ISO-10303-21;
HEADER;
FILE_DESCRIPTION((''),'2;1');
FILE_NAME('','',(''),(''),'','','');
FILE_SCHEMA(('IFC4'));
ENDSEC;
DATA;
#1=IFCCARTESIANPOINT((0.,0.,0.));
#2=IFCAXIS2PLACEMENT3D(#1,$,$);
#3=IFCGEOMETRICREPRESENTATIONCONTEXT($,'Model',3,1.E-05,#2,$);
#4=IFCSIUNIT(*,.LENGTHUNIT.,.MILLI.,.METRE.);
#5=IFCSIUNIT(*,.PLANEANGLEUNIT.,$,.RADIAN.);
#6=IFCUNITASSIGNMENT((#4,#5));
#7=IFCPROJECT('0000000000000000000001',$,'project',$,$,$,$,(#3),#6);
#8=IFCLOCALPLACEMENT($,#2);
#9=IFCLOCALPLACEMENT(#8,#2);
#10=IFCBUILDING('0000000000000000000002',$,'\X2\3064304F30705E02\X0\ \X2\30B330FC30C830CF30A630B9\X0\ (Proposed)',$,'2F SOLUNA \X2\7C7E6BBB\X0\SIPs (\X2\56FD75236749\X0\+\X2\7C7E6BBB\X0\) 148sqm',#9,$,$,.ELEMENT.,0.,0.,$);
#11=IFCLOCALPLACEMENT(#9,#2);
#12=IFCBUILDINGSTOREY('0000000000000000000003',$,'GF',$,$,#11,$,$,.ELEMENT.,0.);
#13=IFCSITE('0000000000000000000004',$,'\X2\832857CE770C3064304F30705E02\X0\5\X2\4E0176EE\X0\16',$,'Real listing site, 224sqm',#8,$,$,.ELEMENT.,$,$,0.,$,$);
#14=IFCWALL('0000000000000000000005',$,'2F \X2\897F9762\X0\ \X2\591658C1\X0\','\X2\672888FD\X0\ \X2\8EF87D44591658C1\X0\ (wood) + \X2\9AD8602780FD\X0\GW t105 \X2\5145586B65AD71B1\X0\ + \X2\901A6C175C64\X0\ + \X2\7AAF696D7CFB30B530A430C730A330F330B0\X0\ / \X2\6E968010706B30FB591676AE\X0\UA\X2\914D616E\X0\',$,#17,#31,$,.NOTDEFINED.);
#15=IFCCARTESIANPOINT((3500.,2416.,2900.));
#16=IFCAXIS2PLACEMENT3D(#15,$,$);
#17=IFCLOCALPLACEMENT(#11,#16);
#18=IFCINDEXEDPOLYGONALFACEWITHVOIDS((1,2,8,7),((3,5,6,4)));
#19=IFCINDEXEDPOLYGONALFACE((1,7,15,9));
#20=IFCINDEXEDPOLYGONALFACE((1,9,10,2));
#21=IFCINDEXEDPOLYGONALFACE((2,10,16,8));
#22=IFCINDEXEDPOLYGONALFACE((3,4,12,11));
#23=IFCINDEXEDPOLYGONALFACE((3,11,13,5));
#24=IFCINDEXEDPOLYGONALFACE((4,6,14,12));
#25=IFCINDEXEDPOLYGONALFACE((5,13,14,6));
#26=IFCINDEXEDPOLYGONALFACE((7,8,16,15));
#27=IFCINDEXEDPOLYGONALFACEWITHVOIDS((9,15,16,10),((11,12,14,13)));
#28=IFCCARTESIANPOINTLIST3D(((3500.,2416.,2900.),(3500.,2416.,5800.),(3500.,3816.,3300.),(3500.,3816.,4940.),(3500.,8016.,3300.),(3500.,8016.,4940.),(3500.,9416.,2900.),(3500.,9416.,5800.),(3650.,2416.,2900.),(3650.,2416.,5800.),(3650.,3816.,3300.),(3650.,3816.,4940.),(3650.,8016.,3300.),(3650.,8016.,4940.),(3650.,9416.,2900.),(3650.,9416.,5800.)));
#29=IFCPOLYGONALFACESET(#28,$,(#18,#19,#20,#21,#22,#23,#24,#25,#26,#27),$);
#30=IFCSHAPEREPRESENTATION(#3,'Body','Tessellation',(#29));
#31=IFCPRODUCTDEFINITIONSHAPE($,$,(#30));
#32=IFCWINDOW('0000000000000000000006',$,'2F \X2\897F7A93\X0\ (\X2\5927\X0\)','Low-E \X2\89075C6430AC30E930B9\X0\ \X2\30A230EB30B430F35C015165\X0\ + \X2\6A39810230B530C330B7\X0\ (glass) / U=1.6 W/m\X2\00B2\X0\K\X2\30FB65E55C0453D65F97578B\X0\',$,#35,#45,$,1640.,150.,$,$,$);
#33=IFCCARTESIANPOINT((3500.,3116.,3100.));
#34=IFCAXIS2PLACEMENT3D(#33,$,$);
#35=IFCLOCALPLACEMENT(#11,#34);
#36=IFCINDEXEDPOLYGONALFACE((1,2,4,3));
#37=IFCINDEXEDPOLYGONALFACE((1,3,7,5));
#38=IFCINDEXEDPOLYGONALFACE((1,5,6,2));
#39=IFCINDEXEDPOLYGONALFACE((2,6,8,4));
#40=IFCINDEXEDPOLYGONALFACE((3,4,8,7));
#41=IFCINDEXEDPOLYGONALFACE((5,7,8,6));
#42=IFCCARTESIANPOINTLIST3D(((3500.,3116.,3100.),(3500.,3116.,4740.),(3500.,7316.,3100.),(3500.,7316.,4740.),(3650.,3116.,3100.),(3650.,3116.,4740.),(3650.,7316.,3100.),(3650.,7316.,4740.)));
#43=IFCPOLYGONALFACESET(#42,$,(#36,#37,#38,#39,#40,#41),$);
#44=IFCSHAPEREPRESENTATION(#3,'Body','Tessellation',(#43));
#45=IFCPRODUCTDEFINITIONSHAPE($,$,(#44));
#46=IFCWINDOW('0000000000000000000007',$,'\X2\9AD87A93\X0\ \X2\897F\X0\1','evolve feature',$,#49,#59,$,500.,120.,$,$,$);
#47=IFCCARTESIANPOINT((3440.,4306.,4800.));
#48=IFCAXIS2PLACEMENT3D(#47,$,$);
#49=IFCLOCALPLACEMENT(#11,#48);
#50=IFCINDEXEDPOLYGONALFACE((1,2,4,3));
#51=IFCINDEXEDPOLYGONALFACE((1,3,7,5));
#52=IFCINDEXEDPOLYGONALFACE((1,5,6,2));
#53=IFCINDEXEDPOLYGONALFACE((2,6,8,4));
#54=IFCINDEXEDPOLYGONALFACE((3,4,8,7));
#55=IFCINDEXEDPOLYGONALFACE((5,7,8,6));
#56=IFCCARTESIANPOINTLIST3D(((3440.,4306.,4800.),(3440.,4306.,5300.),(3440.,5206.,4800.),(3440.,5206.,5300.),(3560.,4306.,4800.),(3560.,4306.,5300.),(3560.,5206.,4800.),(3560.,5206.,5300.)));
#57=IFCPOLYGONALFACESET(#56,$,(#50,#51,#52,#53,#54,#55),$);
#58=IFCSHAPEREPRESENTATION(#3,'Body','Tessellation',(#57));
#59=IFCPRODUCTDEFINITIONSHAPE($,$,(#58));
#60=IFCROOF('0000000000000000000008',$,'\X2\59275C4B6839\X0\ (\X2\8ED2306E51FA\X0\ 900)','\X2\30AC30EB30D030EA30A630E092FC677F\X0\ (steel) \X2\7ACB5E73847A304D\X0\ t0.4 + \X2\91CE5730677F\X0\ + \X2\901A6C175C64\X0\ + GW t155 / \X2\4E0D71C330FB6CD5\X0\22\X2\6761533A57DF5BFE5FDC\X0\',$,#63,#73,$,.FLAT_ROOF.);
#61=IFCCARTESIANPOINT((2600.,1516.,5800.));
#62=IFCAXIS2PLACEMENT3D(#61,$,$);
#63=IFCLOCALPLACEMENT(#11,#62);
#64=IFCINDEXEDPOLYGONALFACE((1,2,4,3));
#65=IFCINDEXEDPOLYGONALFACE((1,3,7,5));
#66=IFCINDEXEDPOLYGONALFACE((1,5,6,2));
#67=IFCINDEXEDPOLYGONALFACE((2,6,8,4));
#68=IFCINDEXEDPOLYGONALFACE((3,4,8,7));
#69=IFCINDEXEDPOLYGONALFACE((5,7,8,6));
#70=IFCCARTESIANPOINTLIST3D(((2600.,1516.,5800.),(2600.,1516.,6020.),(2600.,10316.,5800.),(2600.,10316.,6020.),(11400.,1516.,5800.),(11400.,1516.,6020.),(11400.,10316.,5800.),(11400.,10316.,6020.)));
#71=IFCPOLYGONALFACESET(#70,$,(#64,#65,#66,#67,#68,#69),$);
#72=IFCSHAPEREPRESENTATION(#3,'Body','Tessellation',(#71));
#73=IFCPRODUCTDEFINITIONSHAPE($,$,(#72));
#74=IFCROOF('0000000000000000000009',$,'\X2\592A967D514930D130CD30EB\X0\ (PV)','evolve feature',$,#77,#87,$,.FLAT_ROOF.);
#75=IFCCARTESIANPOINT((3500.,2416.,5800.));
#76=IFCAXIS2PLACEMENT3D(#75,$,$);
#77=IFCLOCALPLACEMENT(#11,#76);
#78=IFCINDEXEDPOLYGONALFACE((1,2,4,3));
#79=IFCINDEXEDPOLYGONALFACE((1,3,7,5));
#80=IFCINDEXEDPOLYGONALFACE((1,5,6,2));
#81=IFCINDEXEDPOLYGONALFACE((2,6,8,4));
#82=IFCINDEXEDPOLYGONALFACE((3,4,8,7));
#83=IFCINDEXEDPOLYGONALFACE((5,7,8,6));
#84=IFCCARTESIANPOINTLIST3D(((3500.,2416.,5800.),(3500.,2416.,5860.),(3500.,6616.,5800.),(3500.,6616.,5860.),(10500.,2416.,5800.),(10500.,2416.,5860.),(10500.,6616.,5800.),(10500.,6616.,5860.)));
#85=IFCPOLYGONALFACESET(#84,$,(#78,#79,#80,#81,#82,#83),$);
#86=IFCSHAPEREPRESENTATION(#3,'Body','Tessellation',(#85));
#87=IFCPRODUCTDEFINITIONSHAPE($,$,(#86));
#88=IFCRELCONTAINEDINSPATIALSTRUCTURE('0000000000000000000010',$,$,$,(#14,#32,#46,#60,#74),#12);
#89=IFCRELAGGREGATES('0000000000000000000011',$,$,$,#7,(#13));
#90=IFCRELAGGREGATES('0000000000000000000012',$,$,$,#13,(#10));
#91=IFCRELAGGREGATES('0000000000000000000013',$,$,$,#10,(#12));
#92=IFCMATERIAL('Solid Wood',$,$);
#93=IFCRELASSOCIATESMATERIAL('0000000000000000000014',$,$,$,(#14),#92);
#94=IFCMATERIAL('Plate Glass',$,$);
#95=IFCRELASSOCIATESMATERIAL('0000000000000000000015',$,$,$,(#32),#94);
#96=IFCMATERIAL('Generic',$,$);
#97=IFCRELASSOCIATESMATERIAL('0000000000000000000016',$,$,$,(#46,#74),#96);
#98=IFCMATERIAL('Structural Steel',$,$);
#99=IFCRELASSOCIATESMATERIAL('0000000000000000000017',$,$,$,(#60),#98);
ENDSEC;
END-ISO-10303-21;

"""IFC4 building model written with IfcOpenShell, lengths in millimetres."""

from ifc_helpers import new_model, si_unit, frame, frame_2d, origin, place, context, project, spatial, rectangle, extrude, material, element, fill, save


model = new_model("IFC4")

# Units and contexts
model_context = context("Model", 3, precision=1e-05, world=origin())
ifc_project = project(units=[si_unit("LENGTHUNIT", "METRE", prefix="MILLI"), si_unit("PLANEANGLEUNIT", "RADIAN")], contexts=[model_context])

# Site, building, storey
site_placement = place(None, origin())
site = spatial("IfcSite", under=ifc_project, at=site_placement, Name="茨城県つくば市5丁目16", ObjectType="Real listing site, 224sqm", CompositionType="ELEMENT", RefElevation=0.0)
building_placement = place(site_placement, origin())
building = spatial("IfcBuilding", under=site, at=building_placement, Name="つくば市 コートハウス (Proposed)", ObjectType="2F SOLUNA 籾殻SIPs (国産杉+籾殻) 148sqm", CompositionType="ELEMENT", ElevationOfRefHeight=0.0, ElevationOfTerrain=0.0)
storey_placement = place(building_placement, origin())
storey = spatial("IfcBuildingStorey", under=building, at=storey_placement, Name="GF", CompositionType="ELEMENT", Elevation=0.0)

# Shared definitions
ifc_material_1 = material(Name="Solid Wood")
ifc_material_2 = material(Name="Generic")

# Shared definitions
ifc_material_3 = material(Name="Plate Glass")

# Wall, openings, windows
wall_1_placement = place(storey_placement, frame((3500.0, 2416.0, 2900.0)))
wall_1 = element("IfcWall", 1, at=wall_1_placement, inside=storey, material=ifc_material_1, Name="2F 西面 外壁", Description="木製 軸組外壁 (wood) + 高性能GW t105 充填断熱 + 通気層 + 窯業系サイディング / 準耐火・外皮UA配慮", PredefinedType="NOTDEFINED", context=model_context, shape_type="SweptSolid", body=[
    extrude(rectangle(XDim=150.0, YDim=7000.0, at=frame_2d((75.0, 3500.0))), frame((3500.0, 2416.0, 2900.0)), (0.0, 0.0, 1.0), 2900.0),
])
opening_1_placement = place(storey_placement, frame((3500.0, 3116.0, 3100.0)))
opening_1 = element("IfcOpeningElement", 2, at=opening_1_placement, cuts=wall_1, PredefinedType="NOTDEFINED", context=model_context, shape_type="SweptSolid", body=[
    extrude(rectangle(XDim=150.0, YDim=4200.0, at=frame_2d((75.0, 2100.0))), frame((3500.0, 3116.0, 3100.0)), (0.0, 0.0, 1.0), 1640.0),
])
opening_2_placement = place(storey_placement, frame((3440.0, 4306.0, 4800.0)))
opening_2 = element("IfcOpeningElement", 3, at=opening_2_placement, cuts=wall_1, PredefinedType="NOTDEFINED", context=model_context, shape_type="SweptSolid", body=[
    extrude(rectangle(XDim=120.0, YDim=900.0, at=frame_2d((60.0, 450.0))), frame((3440.0, 4306.0, 4800.0)), (0.0, 0.0, 1.0), 500.0),
])
window_1_placement = place(storey_placement, frame((3500.0, 3116.0, 3100.0)))
window_1 = element("IfcWindow", 4, at=window_1_placement, inside=storey, material=ifc_material_3, Name="2F 西窓 (大)", Description="Low-E 複層ガラス アルゴン封入 + 樹脂サッシ (glass) / U=1.6 W/m²K・日射取得型", OverallHeight=1640.0, OverallWidth=150.0, context=model_context, shape_type="SweptSolid", body=[
    extrude(rectangle(XDim=150.0, YDim=4200.0, at=frame_2d((75.0, 2100.0))), frame((3500.0, 3116.0, 3100.0)), (0.0, 0.0, 1.0), 1640.0),
])
fill(opening_1, window_1)
window_2_placement = place(storey_placement, frame((3440.0, 4306.0, 4800.0)))
window_2 = element("IfcWindow", 5, at=window_2_placement, inside=storey, material=ifc_material_2, Name="高窓 西1", Description="evolve feature", OverallHeight=500.0, OverallWidth=120.0, context=model_context, shape_type="SweptSolid", body=[
    extrude(rectangle(XDim=120.0, YDim=900.0, at=frame_2d((60.0, 450.0))), frame((3440.0, 4306.0, 4800.0)), (0.0, 0.0, 1.0), 500.0),
])
fill(opening_2, window_2)

# Roofs
ifc_material_4 = material(Name="Structural Steel")
roof_1_placement = place(storey_placement, frame((2600.0, 1516.0, 5800.0)))
element("IfcRoof", 6, at=roof_1_placement, inside=storey, material=ifc_material_4, Name="大屋根 (軒の出 900)", Description="ガルバリウム鋼板 (steel) 立平葺き t0.4 + 野地板 + 通気層 + GW t155 / 不燃・法22条区域対応", PredefinedType="FLAT_ROOF", context=model_context, shape_type="SweptSolid", body=[
    extrude(rectangle(XDim=8800.0, YDim=8800.0, at=frame_2d((4400.0, 4400.0))), frame((2600.0, 1516.0, 5800.0)), (0.0, 0.0, 1.0), 220.0),
])
roof_2_placement = place(storey_placement, frame((3500.0, 2416.0, 5800.0)))
element("IfcRoof", 7, at=roof_2_placement, inside=storey, material=ifc_material_2, Name="太陽光パネル (PV)", Description="evolve feature", PredefinedType="FLAT_ROOF", context=model_context, shape_type="SweptSolid", body=[
    extrude(rectangle(XDim=7000.0, YDim=4200.0, at=frame_2d((3500.0, 2100.0))), frame((3500.0, 2416.0, 5800.0)), (0.0, 0.0, 1.0), 60.0),
])

save(model, "model.ifc")
